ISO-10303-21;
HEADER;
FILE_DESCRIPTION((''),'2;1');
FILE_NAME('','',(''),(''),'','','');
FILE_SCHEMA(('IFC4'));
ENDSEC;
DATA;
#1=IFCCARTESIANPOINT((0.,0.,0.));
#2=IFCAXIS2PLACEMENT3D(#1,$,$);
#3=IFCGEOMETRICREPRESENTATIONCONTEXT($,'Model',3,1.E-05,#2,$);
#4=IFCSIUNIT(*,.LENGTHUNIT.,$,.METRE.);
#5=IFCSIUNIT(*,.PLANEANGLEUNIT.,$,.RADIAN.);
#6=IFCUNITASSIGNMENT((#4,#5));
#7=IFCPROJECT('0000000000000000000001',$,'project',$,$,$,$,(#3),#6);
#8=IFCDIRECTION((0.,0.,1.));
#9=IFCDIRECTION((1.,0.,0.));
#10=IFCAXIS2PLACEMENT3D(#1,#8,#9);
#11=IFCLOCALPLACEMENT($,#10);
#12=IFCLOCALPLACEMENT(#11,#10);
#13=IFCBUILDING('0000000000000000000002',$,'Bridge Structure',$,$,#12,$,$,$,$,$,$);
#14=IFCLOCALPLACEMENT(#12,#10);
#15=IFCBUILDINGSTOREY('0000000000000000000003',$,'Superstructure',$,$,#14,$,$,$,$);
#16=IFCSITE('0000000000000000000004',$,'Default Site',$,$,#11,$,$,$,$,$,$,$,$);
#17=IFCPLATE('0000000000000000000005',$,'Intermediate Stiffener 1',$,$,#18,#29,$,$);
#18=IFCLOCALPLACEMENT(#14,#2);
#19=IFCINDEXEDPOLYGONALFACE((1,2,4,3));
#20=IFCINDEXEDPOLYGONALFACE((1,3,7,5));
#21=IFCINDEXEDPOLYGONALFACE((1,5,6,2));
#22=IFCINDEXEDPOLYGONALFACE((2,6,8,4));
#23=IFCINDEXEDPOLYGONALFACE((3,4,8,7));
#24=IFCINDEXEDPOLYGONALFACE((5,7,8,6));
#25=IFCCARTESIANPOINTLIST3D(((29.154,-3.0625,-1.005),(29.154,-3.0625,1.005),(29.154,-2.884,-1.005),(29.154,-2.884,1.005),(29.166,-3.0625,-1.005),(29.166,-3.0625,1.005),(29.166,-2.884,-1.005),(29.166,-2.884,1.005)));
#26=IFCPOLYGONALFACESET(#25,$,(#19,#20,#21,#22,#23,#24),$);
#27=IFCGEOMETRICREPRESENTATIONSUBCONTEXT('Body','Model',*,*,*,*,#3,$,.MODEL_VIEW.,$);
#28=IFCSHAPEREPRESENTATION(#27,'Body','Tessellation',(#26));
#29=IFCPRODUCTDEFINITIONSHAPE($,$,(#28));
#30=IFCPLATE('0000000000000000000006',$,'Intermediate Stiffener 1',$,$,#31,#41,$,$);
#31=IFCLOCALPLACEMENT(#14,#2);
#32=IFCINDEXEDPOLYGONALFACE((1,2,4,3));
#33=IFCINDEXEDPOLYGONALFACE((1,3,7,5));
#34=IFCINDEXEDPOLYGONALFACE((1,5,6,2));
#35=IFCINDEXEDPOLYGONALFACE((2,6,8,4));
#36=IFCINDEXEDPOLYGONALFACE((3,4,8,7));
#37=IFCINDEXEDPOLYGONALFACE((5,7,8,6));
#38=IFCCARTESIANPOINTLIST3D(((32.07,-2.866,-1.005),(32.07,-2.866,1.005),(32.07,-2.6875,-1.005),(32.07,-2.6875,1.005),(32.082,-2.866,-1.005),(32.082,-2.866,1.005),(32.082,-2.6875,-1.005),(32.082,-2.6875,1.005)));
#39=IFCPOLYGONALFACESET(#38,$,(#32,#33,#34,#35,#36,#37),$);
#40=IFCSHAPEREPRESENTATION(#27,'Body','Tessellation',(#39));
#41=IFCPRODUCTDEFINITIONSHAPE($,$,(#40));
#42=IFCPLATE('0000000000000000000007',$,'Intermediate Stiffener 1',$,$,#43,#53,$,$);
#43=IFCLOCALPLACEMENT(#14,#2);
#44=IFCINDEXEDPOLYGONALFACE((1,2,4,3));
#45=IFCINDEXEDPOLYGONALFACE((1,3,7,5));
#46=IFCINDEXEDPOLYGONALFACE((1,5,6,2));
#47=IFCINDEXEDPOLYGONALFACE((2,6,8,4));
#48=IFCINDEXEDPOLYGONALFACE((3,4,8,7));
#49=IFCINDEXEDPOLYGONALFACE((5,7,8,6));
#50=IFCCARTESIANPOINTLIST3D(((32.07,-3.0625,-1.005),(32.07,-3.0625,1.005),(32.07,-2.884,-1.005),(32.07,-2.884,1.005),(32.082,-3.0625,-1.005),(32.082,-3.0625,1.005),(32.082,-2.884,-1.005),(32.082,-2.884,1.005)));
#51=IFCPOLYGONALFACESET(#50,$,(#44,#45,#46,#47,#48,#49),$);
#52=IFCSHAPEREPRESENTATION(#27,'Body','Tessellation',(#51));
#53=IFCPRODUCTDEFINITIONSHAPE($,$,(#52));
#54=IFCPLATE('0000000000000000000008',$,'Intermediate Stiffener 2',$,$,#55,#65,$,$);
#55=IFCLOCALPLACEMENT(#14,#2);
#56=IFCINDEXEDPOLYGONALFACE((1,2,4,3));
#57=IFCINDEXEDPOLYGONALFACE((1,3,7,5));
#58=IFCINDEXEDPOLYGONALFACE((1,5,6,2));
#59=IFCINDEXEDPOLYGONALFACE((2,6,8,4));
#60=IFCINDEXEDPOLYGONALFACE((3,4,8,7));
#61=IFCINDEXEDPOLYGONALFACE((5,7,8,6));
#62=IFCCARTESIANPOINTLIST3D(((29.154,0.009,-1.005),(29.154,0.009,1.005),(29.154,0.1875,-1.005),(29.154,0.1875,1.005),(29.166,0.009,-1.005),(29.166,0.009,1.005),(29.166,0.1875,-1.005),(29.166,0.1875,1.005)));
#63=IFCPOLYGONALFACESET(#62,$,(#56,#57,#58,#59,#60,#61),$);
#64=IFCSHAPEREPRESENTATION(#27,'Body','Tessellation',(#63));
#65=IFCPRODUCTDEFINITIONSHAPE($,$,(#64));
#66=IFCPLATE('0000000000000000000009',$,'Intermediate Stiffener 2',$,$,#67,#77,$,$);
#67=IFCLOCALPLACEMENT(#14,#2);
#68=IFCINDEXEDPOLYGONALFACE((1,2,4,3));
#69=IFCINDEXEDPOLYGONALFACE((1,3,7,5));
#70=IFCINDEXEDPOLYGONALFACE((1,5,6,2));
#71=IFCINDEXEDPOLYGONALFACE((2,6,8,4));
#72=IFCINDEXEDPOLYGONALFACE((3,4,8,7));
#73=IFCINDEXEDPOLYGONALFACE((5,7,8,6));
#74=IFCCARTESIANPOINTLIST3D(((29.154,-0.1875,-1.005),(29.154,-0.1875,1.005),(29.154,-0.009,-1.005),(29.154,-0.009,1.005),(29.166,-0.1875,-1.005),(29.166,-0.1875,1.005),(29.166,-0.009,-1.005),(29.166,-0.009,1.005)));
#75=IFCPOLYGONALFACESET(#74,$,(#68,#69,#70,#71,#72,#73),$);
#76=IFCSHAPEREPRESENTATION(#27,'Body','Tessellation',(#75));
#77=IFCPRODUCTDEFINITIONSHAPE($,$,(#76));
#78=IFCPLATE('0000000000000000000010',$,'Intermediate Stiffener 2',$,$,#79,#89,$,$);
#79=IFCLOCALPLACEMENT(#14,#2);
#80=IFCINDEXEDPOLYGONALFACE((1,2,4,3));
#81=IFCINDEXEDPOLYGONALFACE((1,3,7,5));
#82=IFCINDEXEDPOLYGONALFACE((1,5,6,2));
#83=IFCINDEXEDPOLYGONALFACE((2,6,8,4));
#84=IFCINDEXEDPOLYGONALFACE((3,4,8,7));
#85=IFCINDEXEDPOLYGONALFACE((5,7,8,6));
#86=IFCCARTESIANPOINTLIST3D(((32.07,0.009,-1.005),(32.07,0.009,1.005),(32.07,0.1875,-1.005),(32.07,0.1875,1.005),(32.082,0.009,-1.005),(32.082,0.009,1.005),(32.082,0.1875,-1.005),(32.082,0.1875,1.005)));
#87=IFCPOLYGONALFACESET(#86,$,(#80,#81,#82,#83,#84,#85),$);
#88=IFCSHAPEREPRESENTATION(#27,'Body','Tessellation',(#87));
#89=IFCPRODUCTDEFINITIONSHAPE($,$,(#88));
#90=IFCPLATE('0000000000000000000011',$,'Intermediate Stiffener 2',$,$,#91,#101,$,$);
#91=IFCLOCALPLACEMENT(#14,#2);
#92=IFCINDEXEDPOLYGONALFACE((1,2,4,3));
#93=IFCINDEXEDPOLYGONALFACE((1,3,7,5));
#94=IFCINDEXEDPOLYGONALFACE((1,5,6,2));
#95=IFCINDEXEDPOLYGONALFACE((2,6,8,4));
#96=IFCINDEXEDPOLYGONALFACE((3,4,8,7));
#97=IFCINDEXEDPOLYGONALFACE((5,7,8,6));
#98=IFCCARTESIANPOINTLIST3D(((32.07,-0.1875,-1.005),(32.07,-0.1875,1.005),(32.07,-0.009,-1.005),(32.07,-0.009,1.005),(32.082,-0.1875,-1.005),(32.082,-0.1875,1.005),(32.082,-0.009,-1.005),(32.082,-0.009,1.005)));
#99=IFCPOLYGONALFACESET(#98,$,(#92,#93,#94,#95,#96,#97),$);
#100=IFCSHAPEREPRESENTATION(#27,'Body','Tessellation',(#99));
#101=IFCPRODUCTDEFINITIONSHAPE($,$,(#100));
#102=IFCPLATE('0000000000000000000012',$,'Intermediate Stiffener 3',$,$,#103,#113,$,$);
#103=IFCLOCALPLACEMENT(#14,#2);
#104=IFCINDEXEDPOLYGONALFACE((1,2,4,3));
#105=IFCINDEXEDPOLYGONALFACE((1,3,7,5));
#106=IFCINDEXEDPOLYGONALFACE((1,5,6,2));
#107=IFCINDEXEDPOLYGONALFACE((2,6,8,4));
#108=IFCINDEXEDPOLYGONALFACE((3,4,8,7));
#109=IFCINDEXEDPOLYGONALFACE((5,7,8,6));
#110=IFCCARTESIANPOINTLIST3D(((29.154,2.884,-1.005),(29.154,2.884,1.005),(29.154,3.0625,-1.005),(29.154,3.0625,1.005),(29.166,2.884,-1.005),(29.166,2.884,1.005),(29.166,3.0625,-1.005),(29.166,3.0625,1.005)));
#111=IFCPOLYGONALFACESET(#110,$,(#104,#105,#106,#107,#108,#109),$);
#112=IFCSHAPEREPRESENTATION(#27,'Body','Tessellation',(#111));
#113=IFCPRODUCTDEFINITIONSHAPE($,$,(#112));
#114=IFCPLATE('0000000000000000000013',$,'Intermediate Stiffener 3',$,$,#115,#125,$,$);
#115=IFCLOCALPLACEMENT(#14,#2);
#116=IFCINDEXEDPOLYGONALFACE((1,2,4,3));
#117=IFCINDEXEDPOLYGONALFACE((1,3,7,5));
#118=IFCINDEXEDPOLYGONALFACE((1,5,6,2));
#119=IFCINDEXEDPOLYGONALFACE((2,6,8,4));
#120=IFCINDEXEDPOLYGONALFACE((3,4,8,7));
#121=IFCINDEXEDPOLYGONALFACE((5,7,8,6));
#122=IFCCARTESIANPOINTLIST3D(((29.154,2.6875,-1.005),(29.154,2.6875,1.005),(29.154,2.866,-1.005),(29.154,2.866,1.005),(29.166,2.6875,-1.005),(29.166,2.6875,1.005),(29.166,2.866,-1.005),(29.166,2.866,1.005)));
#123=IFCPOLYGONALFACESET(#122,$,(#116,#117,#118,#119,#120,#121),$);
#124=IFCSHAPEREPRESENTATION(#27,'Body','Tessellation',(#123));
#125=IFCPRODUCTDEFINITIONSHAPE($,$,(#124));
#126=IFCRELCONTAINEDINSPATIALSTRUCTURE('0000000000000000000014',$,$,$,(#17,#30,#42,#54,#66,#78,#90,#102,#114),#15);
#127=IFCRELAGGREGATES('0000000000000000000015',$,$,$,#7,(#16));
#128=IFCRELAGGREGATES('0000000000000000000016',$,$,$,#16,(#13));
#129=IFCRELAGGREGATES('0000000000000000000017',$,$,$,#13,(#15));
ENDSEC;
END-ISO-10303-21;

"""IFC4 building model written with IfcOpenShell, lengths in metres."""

from ifc_helpers import new_model, si_unit, frame, origin, origin_with_axes, origin_2d_with_axis, place, context, subcontext, project, spatial, rectangle, extrude, element, save


model = new_model("IFC4")

# Units and contexts
model_context = context("Model", 3, precision=1e-05, world=origin())
body_context = subcontext(model_context, "Body", "Model", "MODEL_VIEW")
ifc_project = project(units=[si_unit("LENGTHUNIT", "METRE"), si_unit("PLANEANGLEUNIT", "RADIAN")], contexts=[model_context])

# Site, building, storey
site_placement = place(None, origin_with_axes())
site = spatial("IfcSite", under=ifc_project, at=site_placement, Name="Default Site")
building_placement = place(site_placement, origin_with_axes())
building = spatial("IfcBuilding", under=site, at=building_placement, Name="Bridge Structure")
storey_placement = place(building_placement, origin_with_axes())
storey = spatial("IfcBuildingStorey", under=building, at=storey_placement, Name="Superstructure")

# Plates
for number, where, z_axis, x_axis, name in (
    (1, (29.16, -2.9733, -1.005), (0.0, 0.0, 1.0), (1.0, 0.0, 0.0), "Intermediate Stiffener 1"),
    (2, (32.076, -2.7768, -1.005), (0.0, 0.0, 1.0), (1.0, 0.0, 0.0), "Intermediate Stiffener 1"),
    (3, (32.076, -2.9733, -1.005), (0.0, 0.0, 1.0), (1.0, 0.0, 0.0), "Intermediate Stiffener 1"),
    (4, (29.16, 0.0983, -1.005), (0.0, 0.0, 1.0), (1.0, 0.0, 0.0), "Intermediate Stiffener 2"),
    (5, (29.16, -0.0983, -1.005), (0.0, 0.0, 1.0), (1.0, 0.0, 0.0), "Intermediate Stiffener 2"),
    (6, (32.076, 0.0983, -1.005), (0.0, 0.0, 1.0), (1.0, 0.0, 0.0), "Intermediate Stiffener 2"),
    (7, (32.076, -0.0983, -1.005), (0.0, 0.0, 1.0), (1.0, 0.0, 0.0), "Intermediate Stiffener 2"),
    (8, (29.16, 2.9733, -1.005), (0.0, 0.0, 1.0), (1.0, 0.0, 0.0), "Intermediate Stiffener 3"),
    (9, (29.16, 2.7768, -1.005), (0.0, 0.0, 1.0), (1.0, 0.0, 0.0), "Intermediate Stiffener 3"),
):
    element("IfcPlate", number, at=place(storey_placement, frame(where, z_axis=z_axis, x_axis=x_axis)), inside=storey, Name=name, context=body_context, shape_type="SweptSolid", body=[
        extrude(rectangle(XDim=0.012, YDim=0.1785, at=origin_2d_with_axis()), origin_with_axes(), (0.0, 0.0, 1.0), 2.01),
    ])

save(model, "model.ifc")
